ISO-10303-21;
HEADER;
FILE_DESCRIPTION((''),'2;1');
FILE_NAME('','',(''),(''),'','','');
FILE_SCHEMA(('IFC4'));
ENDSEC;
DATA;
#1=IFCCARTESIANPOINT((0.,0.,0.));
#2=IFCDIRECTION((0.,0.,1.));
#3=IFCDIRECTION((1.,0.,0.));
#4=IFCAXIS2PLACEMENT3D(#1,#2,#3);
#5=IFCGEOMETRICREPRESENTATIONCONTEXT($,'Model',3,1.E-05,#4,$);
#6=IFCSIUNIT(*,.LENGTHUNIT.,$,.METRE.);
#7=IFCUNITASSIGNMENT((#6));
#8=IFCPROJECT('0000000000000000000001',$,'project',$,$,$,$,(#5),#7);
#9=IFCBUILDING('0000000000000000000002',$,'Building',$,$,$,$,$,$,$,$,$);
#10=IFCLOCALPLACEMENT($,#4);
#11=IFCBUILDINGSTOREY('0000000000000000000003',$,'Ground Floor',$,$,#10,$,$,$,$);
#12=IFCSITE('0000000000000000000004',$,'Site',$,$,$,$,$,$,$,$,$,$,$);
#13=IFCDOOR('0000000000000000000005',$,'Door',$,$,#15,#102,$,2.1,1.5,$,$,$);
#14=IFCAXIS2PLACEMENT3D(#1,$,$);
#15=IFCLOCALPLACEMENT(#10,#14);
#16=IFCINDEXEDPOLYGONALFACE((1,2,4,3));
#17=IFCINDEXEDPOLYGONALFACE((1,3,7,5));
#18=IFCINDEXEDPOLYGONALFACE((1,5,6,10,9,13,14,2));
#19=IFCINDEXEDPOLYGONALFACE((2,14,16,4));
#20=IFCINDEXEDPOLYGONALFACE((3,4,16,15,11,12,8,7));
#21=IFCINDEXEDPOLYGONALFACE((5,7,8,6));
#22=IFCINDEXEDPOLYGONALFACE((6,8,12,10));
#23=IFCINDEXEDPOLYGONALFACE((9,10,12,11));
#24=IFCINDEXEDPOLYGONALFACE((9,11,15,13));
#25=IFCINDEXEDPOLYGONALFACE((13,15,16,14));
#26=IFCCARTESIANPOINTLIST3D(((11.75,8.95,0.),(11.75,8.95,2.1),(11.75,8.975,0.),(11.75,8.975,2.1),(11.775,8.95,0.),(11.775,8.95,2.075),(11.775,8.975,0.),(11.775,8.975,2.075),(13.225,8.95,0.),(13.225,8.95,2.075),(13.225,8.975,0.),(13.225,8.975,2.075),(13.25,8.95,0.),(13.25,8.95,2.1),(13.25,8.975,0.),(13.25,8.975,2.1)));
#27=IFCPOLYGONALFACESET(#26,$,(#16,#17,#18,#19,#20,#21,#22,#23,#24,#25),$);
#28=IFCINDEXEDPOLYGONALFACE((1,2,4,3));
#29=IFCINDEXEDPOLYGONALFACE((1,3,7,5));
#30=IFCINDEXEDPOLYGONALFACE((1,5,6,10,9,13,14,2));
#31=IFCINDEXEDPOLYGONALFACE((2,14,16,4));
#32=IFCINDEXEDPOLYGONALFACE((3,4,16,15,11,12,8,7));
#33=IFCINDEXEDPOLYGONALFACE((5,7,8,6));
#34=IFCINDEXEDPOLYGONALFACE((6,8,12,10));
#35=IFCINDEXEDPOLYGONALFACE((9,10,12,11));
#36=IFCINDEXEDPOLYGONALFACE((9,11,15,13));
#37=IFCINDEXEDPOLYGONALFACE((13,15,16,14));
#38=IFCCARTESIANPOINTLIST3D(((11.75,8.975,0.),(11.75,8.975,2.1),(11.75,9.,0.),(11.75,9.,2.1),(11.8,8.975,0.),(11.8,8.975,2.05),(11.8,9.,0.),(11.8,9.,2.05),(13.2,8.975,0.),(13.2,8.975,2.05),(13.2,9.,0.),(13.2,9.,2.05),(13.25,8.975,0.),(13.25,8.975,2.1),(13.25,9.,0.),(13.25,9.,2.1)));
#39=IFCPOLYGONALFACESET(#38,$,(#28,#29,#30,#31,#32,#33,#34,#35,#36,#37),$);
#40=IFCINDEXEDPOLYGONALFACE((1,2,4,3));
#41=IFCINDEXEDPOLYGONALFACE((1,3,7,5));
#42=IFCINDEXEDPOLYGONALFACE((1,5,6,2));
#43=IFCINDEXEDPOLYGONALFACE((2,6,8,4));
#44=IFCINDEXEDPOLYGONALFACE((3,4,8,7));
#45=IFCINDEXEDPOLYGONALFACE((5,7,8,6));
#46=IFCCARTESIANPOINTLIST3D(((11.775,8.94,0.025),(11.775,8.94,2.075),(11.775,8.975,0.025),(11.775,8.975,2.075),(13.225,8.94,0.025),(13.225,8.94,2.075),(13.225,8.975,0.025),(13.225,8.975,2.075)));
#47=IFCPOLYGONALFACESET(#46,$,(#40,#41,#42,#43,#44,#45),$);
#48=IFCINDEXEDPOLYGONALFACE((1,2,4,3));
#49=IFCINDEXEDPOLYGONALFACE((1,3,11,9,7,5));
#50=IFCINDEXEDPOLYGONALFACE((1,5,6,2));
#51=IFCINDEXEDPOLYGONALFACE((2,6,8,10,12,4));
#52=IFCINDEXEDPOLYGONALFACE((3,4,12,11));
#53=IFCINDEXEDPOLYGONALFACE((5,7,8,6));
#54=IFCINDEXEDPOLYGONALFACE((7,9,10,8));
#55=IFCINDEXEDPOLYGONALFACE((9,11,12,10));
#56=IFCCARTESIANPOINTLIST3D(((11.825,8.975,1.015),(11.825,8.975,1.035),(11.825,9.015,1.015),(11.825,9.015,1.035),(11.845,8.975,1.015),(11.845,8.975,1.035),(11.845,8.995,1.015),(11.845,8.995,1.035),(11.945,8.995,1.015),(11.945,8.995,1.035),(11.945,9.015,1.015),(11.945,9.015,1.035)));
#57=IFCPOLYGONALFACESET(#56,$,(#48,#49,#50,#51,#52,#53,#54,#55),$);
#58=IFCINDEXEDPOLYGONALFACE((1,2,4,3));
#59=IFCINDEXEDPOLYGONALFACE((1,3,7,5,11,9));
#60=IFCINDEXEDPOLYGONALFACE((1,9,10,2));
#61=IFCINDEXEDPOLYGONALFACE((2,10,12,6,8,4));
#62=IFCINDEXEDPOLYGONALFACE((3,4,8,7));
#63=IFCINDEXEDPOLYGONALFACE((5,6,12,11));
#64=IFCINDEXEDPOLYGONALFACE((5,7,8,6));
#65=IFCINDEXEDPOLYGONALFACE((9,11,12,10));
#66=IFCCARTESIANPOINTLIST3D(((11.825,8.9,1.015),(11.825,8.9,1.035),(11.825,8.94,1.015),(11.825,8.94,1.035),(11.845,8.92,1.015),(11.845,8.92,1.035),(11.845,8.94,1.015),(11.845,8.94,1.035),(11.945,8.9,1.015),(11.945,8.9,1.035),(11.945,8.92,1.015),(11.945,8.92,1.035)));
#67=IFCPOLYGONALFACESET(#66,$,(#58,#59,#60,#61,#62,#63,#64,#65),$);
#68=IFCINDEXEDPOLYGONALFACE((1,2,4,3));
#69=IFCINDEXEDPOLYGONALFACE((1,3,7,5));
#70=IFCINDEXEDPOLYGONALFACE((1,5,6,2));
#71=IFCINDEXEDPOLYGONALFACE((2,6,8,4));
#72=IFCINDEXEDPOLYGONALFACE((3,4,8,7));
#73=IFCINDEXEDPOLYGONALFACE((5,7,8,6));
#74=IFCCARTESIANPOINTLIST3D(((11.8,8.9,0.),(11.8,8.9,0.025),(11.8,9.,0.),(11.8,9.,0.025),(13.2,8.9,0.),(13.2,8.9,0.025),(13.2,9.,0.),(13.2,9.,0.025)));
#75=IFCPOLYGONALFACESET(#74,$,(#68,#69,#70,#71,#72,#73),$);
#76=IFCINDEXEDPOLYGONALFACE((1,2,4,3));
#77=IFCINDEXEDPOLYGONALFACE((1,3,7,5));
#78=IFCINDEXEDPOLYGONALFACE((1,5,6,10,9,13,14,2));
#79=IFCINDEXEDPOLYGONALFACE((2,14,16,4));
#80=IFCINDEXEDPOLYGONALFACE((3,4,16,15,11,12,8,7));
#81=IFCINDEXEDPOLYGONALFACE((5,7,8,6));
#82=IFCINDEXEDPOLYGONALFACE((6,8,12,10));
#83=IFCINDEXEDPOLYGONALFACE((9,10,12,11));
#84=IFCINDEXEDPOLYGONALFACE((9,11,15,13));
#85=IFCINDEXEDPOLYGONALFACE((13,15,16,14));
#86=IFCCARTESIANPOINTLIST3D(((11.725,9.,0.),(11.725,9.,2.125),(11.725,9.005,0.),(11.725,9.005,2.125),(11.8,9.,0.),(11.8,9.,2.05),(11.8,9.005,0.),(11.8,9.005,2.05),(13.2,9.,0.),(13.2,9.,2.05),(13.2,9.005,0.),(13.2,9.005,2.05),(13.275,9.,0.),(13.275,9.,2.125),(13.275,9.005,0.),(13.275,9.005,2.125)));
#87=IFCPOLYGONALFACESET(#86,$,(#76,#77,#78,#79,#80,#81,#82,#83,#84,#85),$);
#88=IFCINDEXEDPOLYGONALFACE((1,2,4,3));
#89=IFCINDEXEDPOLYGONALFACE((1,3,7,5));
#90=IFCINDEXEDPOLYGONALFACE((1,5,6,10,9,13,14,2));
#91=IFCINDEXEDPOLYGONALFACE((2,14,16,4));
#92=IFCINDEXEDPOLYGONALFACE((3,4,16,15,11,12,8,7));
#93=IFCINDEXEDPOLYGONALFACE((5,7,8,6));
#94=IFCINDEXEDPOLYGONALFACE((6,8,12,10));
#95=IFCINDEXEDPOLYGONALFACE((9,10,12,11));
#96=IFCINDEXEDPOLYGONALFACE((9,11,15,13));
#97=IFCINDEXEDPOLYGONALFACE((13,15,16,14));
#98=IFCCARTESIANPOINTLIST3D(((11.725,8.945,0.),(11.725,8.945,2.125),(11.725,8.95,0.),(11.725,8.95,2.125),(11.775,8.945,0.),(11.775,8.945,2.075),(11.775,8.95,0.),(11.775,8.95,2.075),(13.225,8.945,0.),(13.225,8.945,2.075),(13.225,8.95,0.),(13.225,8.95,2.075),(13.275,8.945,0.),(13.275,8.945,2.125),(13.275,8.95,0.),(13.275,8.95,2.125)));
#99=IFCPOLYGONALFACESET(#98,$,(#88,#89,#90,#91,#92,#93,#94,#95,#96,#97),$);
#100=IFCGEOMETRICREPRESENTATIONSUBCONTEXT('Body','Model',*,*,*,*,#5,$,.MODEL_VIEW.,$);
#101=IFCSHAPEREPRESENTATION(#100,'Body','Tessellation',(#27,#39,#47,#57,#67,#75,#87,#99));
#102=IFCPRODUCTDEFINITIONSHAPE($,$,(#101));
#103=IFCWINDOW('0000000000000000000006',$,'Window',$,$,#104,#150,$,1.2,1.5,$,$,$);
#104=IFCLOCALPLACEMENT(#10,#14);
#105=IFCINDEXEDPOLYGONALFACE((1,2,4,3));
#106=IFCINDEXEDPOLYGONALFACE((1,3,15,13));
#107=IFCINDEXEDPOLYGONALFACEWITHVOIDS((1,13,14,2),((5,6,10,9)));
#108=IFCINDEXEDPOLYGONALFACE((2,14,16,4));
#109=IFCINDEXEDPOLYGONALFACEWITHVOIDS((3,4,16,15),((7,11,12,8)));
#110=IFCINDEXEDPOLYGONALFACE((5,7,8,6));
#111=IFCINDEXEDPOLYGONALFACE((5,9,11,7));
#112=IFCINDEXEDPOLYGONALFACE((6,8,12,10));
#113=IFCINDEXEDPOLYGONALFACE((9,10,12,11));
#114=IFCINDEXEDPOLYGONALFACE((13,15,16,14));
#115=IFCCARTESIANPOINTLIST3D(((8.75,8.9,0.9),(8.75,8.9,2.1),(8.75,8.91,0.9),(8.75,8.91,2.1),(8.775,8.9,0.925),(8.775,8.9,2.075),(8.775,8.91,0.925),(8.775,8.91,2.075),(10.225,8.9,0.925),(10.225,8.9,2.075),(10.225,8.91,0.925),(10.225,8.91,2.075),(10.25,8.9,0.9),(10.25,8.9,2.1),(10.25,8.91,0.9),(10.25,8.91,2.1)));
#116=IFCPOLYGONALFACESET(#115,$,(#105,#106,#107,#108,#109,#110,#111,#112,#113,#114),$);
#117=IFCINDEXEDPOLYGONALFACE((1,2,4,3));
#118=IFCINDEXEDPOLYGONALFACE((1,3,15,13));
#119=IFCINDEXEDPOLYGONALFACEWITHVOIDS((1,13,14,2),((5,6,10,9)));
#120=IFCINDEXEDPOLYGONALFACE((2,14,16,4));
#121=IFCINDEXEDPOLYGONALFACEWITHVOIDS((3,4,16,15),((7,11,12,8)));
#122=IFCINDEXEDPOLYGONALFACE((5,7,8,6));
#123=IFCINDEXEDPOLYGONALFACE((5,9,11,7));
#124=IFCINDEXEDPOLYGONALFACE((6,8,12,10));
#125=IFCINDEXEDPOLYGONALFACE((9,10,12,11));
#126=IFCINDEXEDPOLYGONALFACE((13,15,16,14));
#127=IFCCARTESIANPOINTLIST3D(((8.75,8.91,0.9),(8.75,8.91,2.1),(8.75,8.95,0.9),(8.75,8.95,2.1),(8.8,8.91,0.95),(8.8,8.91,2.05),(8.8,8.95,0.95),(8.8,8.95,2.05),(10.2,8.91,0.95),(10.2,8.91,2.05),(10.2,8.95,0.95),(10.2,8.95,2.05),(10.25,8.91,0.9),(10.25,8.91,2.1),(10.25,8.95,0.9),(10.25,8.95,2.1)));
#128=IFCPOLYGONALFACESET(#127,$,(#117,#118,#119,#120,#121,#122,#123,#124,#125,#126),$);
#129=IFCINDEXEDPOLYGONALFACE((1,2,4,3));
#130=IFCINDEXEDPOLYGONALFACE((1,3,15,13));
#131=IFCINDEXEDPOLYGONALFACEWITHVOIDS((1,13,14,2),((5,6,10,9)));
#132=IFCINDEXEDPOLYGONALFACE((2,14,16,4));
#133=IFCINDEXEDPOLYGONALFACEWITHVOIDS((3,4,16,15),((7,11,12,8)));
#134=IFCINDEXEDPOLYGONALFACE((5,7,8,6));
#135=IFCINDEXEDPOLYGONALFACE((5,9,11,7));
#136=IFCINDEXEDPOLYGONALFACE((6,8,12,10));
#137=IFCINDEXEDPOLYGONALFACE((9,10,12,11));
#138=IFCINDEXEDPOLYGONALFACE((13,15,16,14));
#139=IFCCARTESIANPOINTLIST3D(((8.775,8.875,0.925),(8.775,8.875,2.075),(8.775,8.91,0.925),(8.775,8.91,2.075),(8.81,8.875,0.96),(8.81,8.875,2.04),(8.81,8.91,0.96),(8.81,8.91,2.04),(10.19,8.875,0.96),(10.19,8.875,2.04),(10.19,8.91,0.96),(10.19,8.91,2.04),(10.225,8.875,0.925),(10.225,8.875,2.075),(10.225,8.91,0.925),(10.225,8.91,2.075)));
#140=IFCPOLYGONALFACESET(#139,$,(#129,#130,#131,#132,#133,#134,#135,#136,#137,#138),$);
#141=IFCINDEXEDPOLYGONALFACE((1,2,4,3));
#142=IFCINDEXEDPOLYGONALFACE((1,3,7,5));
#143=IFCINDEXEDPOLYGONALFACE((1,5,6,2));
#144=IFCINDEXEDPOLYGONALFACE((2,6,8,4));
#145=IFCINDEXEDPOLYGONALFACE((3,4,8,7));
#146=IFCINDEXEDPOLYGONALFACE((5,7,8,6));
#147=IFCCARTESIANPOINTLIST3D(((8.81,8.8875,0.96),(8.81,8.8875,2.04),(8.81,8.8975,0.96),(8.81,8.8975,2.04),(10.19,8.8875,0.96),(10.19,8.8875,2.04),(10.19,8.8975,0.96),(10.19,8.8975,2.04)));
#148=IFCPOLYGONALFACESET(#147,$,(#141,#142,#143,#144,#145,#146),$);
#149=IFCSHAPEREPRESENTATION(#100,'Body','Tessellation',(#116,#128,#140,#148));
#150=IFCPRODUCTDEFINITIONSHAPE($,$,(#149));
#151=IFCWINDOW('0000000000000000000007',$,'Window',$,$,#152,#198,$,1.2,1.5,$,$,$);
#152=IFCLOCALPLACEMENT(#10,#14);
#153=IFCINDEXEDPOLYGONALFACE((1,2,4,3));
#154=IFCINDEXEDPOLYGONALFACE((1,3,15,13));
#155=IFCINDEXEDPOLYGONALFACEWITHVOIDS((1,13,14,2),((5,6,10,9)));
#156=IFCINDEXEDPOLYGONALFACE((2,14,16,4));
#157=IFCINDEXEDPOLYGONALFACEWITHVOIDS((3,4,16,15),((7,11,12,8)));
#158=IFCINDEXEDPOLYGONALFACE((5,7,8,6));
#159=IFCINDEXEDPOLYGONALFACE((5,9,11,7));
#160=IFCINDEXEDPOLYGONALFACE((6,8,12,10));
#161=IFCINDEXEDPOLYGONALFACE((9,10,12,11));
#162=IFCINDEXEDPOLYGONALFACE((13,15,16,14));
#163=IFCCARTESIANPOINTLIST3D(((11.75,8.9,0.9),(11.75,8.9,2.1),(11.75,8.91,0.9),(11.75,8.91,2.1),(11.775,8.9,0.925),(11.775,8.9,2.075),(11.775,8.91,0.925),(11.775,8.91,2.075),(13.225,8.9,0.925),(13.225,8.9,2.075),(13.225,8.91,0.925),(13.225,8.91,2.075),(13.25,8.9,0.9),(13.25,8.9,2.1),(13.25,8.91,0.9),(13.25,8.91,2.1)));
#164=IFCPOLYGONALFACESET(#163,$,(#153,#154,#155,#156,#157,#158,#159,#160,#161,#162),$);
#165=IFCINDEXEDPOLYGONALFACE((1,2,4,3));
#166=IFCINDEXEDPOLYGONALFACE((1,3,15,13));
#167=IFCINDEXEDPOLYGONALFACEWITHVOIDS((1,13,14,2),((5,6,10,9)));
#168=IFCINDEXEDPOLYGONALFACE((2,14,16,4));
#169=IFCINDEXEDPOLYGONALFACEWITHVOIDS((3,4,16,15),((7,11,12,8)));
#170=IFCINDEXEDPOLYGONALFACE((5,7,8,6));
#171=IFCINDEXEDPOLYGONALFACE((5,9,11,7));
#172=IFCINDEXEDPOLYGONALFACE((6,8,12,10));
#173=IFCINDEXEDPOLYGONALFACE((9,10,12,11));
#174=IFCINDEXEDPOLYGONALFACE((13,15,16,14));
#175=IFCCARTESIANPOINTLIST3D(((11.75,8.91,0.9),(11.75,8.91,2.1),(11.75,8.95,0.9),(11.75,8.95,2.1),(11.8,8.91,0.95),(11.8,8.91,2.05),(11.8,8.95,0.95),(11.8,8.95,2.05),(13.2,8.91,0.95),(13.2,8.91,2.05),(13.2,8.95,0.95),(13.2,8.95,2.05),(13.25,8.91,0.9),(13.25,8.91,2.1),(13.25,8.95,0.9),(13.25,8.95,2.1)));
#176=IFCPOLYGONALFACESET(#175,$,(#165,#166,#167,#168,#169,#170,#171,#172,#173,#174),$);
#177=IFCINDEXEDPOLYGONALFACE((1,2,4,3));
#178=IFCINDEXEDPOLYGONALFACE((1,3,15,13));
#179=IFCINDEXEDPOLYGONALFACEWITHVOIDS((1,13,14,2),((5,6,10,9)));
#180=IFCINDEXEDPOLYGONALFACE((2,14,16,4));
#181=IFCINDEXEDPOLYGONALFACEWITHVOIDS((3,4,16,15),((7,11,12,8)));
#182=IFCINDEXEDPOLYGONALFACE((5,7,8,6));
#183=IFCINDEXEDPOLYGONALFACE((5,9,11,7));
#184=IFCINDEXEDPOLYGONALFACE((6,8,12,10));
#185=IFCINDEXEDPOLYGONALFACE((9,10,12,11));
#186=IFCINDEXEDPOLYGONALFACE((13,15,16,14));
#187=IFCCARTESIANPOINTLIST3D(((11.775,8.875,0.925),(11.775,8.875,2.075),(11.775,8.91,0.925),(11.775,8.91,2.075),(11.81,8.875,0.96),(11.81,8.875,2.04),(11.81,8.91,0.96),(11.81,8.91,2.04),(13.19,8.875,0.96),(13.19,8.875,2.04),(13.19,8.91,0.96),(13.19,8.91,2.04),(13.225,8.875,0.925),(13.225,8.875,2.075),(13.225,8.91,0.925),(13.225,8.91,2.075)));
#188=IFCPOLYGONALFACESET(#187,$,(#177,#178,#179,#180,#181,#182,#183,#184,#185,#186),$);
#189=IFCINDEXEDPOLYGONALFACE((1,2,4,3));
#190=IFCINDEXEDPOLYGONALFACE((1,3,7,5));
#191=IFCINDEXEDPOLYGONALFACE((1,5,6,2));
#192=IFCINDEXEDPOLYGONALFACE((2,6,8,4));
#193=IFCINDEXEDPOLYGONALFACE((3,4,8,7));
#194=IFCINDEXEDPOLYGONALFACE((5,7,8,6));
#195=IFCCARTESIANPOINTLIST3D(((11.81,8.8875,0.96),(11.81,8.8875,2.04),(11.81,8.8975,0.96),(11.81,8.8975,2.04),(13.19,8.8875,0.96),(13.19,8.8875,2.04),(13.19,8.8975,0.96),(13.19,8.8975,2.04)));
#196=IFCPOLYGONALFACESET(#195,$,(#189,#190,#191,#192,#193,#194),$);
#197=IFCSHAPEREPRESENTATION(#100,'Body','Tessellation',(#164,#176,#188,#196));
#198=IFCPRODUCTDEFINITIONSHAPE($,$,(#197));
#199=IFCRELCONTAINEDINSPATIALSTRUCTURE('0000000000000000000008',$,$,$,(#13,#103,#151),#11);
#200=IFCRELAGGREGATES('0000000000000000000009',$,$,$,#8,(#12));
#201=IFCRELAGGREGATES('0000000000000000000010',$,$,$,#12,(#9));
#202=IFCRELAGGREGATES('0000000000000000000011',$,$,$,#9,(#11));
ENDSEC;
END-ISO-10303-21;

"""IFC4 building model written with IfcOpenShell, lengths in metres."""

from ifc_helpers import new_model, si_unit, frame, origin_with_axes, place, context, subcontext, project, spatial, line, indexed_curve, outline, extrude, element, save


model = new_model("IFC4")

# Units and contexts
model_context = context("Model", 3, precision=1e-05, world=origin_with_axes())
body_context = subcontext(model_context, "Body", "Model", "MODEL_VIEW")
ifc_project = project(units=[si_unit("LENGTHUNIT", "METRE")], contexts=[model_context])

# Site, building, storey
site = spatial("IfcSite", under=ifc_project, Name="Site")
building = spatial("IfcBuilding", under=site, Name="Building")
storey_placement = place(None, origin_with_axes())
storey = spatial("IfcBuildingStorey", under=building, at=storey_placement, Name="Ground Floor")

# Door
door_1_placement = place(storey_placement, frame((13.25, 9.0, 0.0), z_axis=(0.0, 0.0, 1.0), x_axis=(-1.0, 0.0, 0.0)))
element("IfcDoor", 1, at=door_1_placement, inside=storey, Name="Door", OverallHeight=2.1, OverallWidth=1.5, context=body_context, shape_type="SweptSolid", body=[
    extrude(outline(indexed_curve([(0.0, 0.0), (0.0, 2.1), (1.5, 2.1), (1.5, 0.0), (1.475, 0.0), (1.475, 2.075), (0.025, 2.075), (0.025, 0.0)], segments=[line(1, 2, 3, 4, 5, 6, 7, 8, 1)])), frame((0.0, 0.025, 0.0), z_axis=(0.0, -1.0, 0.0), x_axis=(1.0, 0.0, 0.0)), (0.0, 0.0, -1.0), 0.025),
    extrude(outline(indexed_curve([(0.0, 0.0), (0.0, 2.1), (1.5, 2.1), (1.5, 0.0), (1.45, 0.0), (1.45, 2.05), (0.05, 2.05), (0.05, 0.0)], segments=[line(1, 2, 3, 4, 5, 6, 7, 8, 1)])), frame((0.0, 0.0, 0.0), z_axis=(0.0, -1.0, 0.0), x_axis=(1.0, 0.0, 0.0)), (0.0, 0.0, -1.0), 0.025),
    extrude(outline(indexed_curve([(0.0, 0.0), (1.45, 0.0), (1.45, 0.035), (0.0, 0.035)], segments=[line(1, 2, 3, 4, 1)])), frame((0.025, 0.025, 0.025), z_axis=(0.0, 0.0, 1.0), x_axis=(1.0, 0.0, 0.0)), (0.0, 0.0, 1.0), 2.05),
    extrude(outline(indexed_curve([(0.0, 0.0), (0.0, -0.04), (-0.12, -0.04), (-0.12, -0.02), (-0.02, -0.02), (-0.02, 0.0)], segments=[line(1, 2, 3, 4, 5, 6, 1)])), frame((1.425, 0.025, 1.015), z_axis=(0.0, 0.0, 1.0), x_axis=(1.0, 0.0, 0.0)), (0.0, 0.0, 1.0), 0.02),
    extrude(outline(indexed_curve([(0.0, 0.0), (0.0, 0.04), (-0.12, 0.04), (-0.12, 0.02), (-0.02, 0.02), (-0.02, 0.0)], segments=[line(1, 2, 3, 4, 5, 6, 1)])), frame((1.425, 0.06, 1.015), z_axis=(0.0, 0.0, 1.0), x_axis=(1.0, 0.0, 0.0)), (0.0, 0.0, 1.0), 0.02),
    extrude(outline(indexed_curve([(0.0, 0.0), (1.4, 0.0), (1.4, 0.1), (0.0, 0.1)], segments=[line(1, 2, 3, 4, 1)])), frame((0.05, 0.0, 0.0), z_axis=(0.0, 0.0, 1.0), x_axis=(1.0, 0.0, 0.0)), (0.0, 0.0, 1.0), 0.025),
    extrude(outline(indexed_curve([(0.0, 0.0), (0.0, 2.125), (1.55, 2.125), (1.55, 0.0), (1.475, 0.0), (1.475, 2.05), (0.075, 2.05), (0.075, 0.0)], segments=[line(1, 2, 3, 4, 5, 6, 7, 8, 1)])), frame((-0.025, -0.005, 0.0), z_axis=(0.0, -1.0, 0.0), x_axis=(1.0, 0.0, 0.0)), (0.0, 0.0, -1.0), 0.005),
    extrude(outline(indexed_curve([(0.0, 0.0), (0.0, 2.125), (1.55, 2.125), (1.55, 0.0), (1.5, 0.0), (1.5, 2.075), (0.05, 2.075), (0.05, 0.0)], segments=[line(1, 2, 3, 4, 5, 6, 7, 8, 1)])), frame((-0.025, 0.05, 0.0), z_axis=(0.0, -1.0, 0.0), x_axis=(1.0, 0.0, 0.0)), (0.0, 0.0, -1.0), 0.005),
])

# Windows
for number, where, z_axis, x_axis, name in (
    (2, (10.25, 9.0, 0.9), (0.0, 0.0, 1.0), (-1.0, 0.0, 0.0), "Window"),
    (3, (13.25, 9.0, 0.9), (0.0, 0.0, 1.0), (-1.0, 0.0, 0.0), "Window"),
):
    element("IfcWindow", number, at=place(storey_placement, frame(where, z_axis=z_axis, x_axis=x_axis)), inside=storey, Name=name, OverallHeight=1.2, OverallWidth=1.5, context=body_context, shape_type="SweptSolid", body=[
        extrude(outline(indexed_curve([(0.0, 0.0), (1.5, 0.0), (1.5, 1.2), (0.0, 1.2)], segments=[line(1, 2, 3, 4, 1)]), holes=[indexed_curve([(0.025, 0.025), (1.475, 0.025), (1.475, 1.175), (0.025, 1.175)], segments=[line(1, 2, 3, 4, 1)])]), frame((0.0, 0.09, 0.0), z_axis=(0.0, -1.0, 0.0), x_axis=(1.0, 0.0, 0.0)), (0.0, 0.0, -1.0), 0.01),
        extrude(outline(indexed_curve([(0.0, 0.0), (1.5, 0.0), (1.5, 1.2), (0.0, 1.2)], segments=[line(1, 2, 3, 4, 1)]), holes=[indexed_curve([(0.05, 0.05), (1.45, 0.05), (1.45, 1.15), (0.05, 1.15)], segments=[line(1, 2, 3, 4, 1)])]), frame((0.0, 0.05, 0.0), z_axis=(0.0, -1.0, 0.0), x_axis=(1.0, 0.0, 0.0)), (0.0, 0.0, -1.0), 0.04),
        extrude(outline(indexed_curve([(0.0, 0.0), (1.45, 0.0), (1.45, 1.15), (0.0, 1.15)], segments=[line(1, 2, 3, 4, 1)]), holes=[indexed_curve([(0.035, 0.035), (1.415, 0.035), (1.415, 1.115), (0.035, 1.115)], segments=[line(1, 2, 3, 4, 1)])]), frame((0.025, 0.09, 0.025), z_axis=(0.0, -1.0, 0.0), x_axis=(1.0, 0.0, 0.0)), (0.0, 0.0, -1.0), 0.035),
        extrude(outline(indexed_curve([(0.035, 0.035), (1.415, 0.035), (1.415, 1.115), (0.035, 1.115)], segments=[line(1, 2, 3, 4, 1)])), frame((0.025, 0.1025, 0.025), z_axis=(0.0, -1.0, 0.0), x_axis=(1.0, 0.0, 0.0)), (0.0, 0.0, -1.0), 0.01),
    ])

save(model, "model.ifc")
